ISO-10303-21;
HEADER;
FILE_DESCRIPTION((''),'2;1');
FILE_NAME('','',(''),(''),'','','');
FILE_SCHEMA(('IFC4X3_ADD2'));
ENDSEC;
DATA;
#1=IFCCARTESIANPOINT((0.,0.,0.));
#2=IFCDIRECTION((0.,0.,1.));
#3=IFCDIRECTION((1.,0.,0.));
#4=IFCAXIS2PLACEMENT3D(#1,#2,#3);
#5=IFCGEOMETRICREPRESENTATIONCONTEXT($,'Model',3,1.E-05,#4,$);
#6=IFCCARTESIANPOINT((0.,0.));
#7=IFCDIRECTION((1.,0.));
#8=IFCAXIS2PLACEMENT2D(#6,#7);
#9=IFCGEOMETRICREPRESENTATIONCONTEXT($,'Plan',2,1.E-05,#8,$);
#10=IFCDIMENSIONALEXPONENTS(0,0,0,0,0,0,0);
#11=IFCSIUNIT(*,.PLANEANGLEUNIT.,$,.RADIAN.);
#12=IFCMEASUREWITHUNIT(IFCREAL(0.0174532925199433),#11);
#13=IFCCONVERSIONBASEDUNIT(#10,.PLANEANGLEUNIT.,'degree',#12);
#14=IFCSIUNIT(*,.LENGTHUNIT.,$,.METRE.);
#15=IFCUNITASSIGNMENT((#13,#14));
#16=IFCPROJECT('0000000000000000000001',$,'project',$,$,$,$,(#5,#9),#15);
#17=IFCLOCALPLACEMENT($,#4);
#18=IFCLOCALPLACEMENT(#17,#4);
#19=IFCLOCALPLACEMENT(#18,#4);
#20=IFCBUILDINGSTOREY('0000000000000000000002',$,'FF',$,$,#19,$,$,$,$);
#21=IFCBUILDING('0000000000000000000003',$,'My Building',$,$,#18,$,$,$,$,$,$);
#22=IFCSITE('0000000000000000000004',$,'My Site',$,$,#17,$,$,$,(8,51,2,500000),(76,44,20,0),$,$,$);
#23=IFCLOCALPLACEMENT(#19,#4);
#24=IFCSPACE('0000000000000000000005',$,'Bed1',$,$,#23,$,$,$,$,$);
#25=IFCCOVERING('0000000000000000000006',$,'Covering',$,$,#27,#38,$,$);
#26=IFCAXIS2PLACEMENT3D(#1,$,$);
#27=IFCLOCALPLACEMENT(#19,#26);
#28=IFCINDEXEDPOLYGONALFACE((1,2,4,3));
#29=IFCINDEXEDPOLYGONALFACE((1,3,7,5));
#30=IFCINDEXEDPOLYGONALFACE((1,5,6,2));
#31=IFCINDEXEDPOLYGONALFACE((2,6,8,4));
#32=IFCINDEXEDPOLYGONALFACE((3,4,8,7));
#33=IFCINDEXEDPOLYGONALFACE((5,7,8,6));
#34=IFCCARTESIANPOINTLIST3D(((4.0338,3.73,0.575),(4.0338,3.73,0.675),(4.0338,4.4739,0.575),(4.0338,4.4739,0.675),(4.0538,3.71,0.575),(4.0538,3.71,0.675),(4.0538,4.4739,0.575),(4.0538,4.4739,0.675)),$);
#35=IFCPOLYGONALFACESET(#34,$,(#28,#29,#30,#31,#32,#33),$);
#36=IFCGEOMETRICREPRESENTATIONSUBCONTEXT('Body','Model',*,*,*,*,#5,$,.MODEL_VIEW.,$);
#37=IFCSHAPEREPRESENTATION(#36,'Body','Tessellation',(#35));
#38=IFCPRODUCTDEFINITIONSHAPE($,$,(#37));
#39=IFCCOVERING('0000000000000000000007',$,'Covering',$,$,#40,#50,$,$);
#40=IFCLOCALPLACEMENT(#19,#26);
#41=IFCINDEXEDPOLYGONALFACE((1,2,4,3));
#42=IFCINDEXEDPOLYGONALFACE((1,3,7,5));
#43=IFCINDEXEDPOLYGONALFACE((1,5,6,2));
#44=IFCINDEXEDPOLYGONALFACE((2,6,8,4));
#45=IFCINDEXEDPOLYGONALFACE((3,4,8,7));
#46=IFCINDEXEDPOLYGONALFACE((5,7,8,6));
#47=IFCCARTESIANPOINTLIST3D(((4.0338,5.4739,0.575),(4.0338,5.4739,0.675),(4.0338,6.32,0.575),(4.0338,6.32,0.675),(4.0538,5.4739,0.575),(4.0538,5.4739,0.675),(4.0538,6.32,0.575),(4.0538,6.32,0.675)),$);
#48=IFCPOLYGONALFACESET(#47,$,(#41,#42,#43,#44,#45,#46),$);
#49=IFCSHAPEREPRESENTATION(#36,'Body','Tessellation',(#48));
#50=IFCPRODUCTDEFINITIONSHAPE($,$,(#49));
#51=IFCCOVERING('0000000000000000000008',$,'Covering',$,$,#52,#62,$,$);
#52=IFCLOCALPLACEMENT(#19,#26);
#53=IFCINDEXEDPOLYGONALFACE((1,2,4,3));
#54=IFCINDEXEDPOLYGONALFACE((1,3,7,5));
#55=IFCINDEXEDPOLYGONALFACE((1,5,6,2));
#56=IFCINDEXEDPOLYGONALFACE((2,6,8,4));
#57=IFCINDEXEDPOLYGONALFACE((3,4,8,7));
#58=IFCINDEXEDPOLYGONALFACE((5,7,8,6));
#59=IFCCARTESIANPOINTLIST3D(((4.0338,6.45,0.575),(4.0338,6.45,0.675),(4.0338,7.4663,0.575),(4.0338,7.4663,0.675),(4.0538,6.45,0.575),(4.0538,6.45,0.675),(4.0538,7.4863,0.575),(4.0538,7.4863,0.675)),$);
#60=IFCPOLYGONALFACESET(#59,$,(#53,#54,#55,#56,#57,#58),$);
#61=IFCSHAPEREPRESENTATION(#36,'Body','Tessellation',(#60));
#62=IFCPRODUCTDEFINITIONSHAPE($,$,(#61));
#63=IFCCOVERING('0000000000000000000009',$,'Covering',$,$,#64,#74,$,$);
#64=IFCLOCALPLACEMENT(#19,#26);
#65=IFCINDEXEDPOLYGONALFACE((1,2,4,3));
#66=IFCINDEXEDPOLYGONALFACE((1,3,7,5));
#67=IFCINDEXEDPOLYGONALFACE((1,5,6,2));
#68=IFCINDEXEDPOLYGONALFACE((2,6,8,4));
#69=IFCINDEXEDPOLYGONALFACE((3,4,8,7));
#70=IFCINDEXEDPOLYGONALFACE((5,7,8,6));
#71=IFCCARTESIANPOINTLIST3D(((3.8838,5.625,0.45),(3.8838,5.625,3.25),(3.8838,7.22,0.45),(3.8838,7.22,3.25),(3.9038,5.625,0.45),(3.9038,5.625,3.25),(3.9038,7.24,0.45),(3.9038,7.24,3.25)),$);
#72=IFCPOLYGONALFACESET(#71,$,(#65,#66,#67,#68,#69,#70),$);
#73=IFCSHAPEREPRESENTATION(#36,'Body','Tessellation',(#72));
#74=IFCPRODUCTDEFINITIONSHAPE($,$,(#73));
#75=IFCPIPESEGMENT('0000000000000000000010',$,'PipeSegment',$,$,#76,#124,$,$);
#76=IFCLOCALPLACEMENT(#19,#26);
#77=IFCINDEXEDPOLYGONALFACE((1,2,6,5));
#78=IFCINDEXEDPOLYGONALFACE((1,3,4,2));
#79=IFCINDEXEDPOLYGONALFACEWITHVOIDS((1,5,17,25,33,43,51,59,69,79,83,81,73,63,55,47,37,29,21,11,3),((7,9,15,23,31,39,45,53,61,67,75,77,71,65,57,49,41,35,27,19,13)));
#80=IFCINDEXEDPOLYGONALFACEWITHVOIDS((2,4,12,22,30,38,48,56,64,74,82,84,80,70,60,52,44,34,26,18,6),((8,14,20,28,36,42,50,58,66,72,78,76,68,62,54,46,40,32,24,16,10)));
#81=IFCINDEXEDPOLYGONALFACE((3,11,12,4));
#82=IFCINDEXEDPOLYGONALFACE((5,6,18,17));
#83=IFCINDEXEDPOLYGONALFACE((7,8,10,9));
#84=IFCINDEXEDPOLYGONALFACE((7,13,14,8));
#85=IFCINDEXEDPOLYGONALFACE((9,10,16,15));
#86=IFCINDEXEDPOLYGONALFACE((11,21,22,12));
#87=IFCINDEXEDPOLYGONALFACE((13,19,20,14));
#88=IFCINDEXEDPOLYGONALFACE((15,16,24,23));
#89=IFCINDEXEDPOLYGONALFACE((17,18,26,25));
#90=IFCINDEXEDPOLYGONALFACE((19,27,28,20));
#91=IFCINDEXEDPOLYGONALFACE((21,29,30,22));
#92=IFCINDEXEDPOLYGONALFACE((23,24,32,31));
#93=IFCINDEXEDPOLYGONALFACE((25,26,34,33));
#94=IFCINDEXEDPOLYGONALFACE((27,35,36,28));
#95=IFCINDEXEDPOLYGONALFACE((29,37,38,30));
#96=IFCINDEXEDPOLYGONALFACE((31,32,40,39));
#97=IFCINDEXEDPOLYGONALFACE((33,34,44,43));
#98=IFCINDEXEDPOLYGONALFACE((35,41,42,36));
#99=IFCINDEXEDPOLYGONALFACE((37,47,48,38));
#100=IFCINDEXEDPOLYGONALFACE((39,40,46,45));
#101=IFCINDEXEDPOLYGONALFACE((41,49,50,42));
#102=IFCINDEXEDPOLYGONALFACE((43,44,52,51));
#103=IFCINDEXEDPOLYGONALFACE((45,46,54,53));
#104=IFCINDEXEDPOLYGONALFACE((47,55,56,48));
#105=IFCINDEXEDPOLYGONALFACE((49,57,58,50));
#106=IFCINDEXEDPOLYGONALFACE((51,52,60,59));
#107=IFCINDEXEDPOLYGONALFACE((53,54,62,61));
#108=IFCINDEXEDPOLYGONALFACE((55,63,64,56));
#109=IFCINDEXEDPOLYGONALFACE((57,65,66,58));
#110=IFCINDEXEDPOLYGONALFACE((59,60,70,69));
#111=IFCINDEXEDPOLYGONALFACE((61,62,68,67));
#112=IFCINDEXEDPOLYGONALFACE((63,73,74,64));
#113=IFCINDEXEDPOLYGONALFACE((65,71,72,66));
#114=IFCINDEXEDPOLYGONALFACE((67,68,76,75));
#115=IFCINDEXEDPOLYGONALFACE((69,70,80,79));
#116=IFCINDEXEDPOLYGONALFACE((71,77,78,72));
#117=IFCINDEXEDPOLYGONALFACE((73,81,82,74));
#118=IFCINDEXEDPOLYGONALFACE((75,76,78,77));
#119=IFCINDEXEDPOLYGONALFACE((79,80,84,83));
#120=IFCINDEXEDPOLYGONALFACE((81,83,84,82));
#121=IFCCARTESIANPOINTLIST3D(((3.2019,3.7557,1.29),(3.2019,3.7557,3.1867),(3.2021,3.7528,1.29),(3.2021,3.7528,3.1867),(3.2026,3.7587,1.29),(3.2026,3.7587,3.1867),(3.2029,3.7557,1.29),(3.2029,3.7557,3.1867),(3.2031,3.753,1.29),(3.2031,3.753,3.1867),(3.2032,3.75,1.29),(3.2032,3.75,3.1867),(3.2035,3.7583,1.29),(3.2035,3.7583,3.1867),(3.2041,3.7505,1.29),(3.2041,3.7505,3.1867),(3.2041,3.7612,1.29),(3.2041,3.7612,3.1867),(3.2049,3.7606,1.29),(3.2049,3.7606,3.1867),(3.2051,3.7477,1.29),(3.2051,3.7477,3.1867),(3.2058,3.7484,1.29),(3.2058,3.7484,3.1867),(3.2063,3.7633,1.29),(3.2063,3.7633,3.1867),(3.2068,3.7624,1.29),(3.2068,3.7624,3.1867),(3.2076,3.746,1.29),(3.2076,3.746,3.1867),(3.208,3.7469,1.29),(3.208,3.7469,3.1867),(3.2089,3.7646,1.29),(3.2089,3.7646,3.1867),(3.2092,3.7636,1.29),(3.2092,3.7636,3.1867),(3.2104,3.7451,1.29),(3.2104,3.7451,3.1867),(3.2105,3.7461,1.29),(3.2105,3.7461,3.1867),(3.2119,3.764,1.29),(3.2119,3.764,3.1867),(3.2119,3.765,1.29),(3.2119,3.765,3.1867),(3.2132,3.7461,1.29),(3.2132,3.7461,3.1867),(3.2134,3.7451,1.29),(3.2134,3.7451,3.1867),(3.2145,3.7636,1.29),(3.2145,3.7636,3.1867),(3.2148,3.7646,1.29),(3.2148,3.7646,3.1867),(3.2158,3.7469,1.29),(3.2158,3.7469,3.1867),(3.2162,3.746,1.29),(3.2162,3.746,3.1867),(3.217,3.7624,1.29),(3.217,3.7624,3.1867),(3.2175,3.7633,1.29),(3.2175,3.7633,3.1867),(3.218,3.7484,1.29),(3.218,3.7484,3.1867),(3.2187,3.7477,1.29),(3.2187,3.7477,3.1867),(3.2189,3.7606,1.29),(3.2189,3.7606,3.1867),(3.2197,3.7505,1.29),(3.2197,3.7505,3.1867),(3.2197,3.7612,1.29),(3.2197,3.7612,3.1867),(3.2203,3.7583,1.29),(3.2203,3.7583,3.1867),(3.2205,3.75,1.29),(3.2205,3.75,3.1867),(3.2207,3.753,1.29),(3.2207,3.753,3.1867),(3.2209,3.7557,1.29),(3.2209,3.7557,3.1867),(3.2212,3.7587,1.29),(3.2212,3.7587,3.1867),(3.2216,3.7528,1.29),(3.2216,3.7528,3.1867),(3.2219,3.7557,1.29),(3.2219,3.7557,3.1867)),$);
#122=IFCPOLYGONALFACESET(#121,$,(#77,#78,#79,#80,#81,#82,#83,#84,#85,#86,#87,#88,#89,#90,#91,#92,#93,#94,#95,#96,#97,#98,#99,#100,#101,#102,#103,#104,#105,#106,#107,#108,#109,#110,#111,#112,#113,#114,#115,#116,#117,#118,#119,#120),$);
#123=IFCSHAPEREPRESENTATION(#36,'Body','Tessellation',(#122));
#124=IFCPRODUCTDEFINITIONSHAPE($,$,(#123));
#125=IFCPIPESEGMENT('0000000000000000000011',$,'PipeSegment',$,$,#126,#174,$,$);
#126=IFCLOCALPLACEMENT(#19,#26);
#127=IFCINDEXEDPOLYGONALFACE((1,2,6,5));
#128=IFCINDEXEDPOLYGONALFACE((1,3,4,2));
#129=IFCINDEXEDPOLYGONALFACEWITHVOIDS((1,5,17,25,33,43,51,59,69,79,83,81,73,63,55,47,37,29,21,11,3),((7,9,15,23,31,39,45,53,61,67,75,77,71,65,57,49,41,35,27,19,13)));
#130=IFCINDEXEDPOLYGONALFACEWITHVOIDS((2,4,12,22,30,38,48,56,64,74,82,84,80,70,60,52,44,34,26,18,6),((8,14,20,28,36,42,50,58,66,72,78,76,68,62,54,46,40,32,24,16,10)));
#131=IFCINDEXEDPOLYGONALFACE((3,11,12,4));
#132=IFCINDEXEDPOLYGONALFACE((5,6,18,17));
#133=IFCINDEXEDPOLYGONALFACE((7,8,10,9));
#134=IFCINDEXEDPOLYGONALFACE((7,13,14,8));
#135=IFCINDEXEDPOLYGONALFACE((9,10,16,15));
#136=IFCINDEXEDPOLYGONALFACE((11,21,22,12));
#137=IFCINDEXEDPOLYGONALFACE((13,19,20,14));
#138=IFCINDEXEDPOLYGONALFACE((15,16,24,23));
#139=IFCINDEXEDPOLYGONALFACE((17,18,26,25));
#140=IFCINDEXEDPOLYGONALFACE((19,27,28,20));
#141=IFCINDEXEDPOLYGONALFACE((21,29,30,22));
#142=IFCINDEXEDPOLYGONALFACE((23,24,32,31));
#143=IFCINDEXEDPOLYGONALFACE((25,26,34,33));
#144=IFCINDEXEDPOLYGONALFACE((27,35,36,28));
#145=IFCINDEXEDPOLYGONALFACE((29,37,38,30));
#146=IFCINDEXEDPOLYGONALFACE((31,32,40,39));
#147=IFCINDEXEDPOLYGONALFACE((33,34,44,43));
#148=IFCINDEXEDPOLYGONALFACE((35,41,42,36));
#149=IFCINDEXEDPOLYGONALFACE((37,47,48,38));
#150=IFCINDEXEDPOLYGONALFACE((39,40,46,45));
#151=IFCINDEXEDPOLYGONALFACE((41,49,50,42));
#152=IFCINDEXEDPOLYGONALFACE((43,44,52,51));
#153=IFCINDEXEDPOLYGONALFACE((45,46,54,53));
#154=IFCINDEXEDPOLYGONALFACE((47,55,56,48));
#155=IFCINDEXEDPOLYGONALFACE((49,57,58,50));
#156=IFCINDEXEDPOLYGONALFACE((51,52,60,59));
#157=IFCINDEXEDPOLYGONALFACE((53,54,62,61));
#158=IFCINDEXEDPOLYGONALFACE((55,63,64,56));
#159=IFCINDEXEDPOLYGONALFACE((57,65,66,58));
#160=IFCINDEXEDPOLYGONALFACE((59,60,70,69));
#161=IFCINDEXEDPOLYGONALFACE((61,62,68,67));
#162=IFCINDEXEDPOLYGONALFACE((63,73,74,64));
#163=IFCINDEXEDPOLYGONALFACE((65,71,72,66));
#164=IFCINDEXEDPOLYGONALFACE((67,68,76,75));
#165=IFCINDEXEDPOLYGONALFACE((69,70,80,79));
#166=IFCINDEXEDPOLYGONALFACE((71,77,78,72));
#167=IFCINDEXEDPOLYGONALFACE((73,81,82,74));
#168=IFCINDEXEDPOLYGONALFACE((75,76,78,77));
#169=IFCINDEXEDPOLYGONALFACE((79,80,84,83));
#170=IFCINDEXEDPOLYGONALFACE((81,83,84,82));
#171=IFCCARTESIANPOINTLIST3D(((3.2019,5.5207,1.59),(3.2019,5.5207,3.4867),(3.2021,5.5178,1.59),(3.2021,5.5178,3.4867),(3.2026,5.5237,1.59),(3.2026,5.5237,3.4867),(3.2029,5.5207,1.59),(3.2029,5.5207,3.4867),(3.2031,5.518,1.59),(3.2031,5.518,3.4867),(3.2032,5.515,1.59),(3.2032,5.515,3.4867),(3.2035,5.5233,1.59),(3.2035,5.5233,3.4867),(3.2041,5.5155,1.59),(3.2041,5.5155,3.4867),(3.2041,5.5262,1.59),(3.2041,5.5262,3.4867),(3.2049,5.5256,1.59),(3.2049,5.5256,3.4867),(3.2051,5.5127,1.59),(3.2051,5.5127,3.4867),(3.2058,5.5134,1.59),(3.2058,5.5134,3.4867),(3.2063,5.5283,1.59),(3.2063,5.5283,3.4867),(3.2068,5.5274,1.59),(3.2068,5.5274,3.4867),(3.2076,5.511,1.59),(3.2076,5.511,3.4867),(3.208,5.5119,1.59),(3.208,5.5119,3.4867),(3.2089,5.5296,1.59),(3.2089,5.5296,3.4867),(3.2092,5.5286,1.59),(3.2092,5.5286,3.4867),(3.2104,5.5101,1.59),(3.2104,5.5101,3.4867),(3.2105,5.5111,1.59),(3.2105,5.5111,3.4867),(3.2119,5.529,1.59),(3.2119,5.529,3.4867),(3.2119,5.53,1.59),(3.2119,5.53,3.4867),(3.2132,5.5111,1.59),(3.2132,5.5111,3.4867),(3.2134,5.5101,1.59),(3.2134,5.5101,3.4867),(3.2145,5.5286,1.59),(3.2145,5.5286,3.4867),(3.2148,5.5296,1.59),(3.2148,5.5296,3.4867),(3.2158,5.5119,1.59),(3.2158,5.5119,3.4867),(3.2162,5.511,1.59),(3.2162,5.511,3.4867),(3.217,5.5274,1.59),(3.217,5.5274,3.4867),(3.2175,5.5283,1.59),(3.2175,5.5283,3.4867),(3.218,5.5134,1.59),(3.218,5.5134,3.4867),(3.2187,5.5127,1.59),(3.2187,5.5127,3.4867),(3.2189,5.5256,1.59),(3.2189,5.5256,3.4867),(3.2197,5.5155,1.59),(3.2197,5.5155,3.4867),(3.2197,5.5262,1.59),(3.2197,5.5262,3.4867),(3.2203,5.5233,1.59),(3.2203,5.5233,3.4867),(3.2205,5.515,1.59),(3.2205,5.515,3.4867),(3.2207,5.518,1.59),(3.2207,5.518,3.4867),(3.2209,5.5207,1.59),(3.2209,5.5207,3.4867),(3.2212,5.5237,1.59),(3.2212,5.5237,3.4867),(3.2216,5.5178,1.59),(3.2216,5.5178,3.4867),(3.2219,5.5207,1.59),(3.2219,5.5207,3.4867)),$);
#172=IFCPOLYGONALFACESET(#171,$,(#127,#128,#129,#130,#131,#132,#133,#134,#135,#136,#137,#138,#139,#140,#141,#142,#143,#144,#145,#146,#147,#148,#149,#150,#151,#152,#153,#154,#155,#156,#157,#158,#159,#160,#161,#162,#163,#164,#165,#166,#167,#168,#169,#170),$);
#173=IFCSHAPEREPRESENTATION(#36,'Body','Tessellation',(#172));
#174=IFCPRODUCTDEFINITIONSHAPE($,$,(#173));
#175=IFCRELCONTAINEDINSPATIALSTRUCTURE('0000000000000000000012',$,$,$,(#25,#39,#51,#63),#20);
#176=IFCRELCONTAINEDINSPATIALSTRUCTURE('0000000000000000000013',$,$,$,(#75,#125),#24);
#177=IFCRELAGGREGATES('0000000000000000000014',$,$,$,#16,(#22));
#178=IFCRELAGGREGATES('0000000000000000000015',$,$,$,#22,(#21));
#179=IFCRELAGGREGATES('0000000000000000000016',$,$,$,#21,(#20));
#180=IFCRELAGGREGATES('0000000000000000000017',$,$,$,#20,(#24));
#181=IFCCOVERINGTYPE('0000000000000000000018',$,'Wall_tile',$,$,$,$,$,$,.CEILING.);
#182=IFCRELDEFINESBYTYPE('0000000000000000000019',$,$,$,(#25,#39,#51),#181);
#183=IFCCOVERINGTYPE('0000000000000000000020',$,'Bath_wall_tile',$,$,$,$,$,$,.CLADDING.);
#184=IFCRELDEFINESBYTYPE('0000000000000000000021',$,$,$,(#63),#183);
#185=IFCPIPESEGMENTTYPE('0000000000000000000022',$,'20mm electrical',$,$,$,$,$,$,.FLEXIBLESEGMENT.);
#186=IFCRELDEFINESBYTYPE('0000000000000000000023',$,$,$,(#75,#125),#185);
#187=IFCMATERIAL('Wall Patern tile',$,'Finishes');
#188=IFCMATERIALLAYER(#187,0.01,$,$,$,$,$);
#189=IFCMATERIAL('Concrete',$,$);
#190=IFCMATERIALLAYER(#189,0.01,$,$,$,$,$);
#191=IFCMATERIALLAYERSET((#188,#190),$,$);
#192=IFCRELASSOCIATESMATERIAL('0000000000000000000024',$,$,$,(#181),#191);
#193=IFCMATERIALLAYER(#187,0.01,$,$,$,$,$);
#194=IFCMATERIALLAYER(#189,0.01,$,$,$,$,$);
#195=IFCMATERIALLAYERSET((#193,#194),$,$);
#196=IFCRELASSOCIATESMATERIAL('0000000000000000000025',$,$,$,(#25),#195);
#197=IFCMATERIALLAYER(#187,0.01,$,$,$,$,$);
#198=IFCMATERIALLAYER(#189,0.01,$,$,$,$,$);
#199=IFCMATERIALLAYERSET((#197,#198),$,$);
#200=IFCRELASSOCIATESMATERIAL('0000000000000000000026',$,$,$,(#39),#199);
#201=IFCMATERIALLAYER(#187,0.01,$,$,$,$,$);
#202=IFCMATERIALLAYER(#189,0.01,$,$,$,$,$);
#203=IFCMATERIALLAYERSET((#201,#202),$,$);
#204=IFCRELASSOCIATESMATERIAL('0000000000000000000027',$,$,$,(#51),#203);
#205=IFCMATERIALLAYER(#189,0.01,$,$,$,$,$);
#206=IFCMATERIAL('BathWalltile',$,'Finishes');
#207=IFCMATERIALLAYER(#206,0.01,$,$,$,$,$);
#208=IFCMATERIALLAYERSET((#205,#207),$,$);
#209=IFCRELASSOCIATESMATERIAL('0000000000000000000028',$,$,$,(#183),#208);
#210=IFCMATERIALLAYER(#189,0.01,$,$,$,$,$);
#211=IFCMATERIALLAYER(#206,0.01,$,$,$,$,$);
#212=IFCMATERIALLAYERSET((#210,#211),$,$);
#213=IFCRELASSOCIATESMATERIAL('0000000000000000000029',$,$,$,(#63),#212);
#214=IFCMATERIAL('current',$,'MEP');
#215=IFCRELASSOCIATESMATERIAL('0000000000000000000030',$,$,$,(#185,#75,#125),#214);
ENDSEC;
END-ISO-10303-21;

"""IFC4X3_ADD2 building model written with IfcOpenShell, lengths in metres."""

from ifc_helpers import new_model, entity, si_unit, converted_unit, frame, origin_with_axes, origin_2d_with_axis, place, context, subcontext, project, spatial, line, indexed_curve, hollow_circle, outline, extrude, material, layer, layer_set, layer_usage, material_profile, profile_set, profile_usage, type_object, element, save


model = new_model("IFC4X3_ADD2")

# Units and contexts
model_context = context("Model", 3, precision=1e-05, world=origin_with_axes())
plan_context = context("Plan", 2, precision=1e-05, world=origin_2d_with_axis())
body_context_1 = subcontext(model_context, "Body", "Model", "MODEL_VIEW")
ifc_project = project(units=[converted_unit("PLANEANGLEUNIT", "degree", entity("IfcReal", 0.0174532925199433), si_unit("PLANEANGLEUNIT", "RADIAN"), dimensions=[0, 0, 0, 0, 0, 0, 0]), si_unit("LENGTHUNIT", "METRE")], contexts=[model_context, plan_context])

# Site, building, storey
site_placement = place(None, origin_with_axes())
site = spatial("IfcSite", under=ifc_project, at=site_placement, Name="My Site", RefLatitude=(8, 51, 2, 500000), RefLongitude=(76, 44, 20, 0))
building_placement = place(site_placement, origin_with_axes())
building = spatial("IfcBuilding", under=site, at=building_placement, Name="My Building")
storey_placement = place(building_placement, origin_with_axes())
storey = spatial("IfcBuildingStorey", under=building, at=storey_placement, Name="FF")

# Coverings
ifc_material_1 = material(Name="Wall Patern tile", Category="Finishes")
ifc_material_2 = material(Name="Concrete")
ifc_layer_1 = layer(ifc_material_1, 0.01)
ifc_layer_2 = layer(ifc_material_2, 0.01)
ifc_layer_set_1 = layer_set([ifc_layer_1, ifc_layer_2])
covering_type_1 = type_object("IfcCoveringType", Name="Wall_tile", PredefinedType="CEILING", material=ifc_layer_set_1)
ifc_layer_3 = layer(ifc_material_1, 0.01)
ifc_layer_4 = layer(ifc_material_2, 0.01)
ifc_layer_set_2 = layer_set([ifc_layer_3, ifc_layer_4])
ifc_layer_usage_1 = layer_usage(ifc_layer_set_2, "AXIS2", "NEGATIVE", 0.0)
covering_1_placement = place(storey_placement, frame((4.0538, 4.4739, 0.575), z_axis=(0.0, 0.0, 1.0), x_axis=(0.0, -1.0, 0.0)))
element("IfcCovering", 1, at=covering_1_placement, inside=storey, type_object=covering_type_1, material=ifc_layer_usage_1, Name="Covering", context=body_context_1, shape_type="SweptSolid", body=[
    extrude(outline(indexed_curve([(0.0, -0.02), (0.0, 0.0), (0.7639, 0.0), (0.7439, -0.02)], segments=[line(1, 2, 3, 4, 1)])), origin_with_axes(), (0.0, 0.0, 1.0), 0.1),
])
ifc_layer_5 = layer(ifc_material_1, 0.01)
ifc_layer_6 = layer(ifc_material_2, 0.01)
ifc_layer_set_3 = layer_set([ifc_layer_5, ifc_layer_6])
ifc_layer_usage_2 = layer_usage(ifc_layer_set_3, "AXIS2", "NEGATIVE", 0.0)
covering_2_placement = place(storey_placement, frame((4.0538, 6.32, 0.575), z_axis=(0.0, 0.0, 1.0), x_axis=(0.0, -1.0, 0.0)))
element("IfcCovering", 2, at=covering_2_placement, inside=storey, type_object=covering_type_1, material=ifc_layer_usage_2, Name="Covering", context=body_context_1, shape_type="SweptSolid", body=[
    extrude(outline(indexed_curve([(0.0, -0.02), (0.0, 0.0), (0.8461, 0.0), (0.8461, -0.02)], segments=[line(1, 2, 3, 4, 1)])), origin_with_axes(), (0.0, 0.0, 1.0), 0.1),
])
ifc_layer_7 = layer(ifc_material_1, 0.01)
ifc_layer_8 = layer(ifc_material_2, 0.01)
ifc_layer_set_4 = layer_set([ifc_layer_7, ifc_layer_8])
ifc_layer_usage_3 = layer_usage(ifc_layer_set_4, "AXIS2", "NEGATIVE", 0.0)
covering_3_placement = place(storey_placement, frame((4.0538, 7.4863, 0.575), z_axis=(0.0, 0.0, 1.0), x_axis=(0.0, -1.0, 0.0)))
element("IfcCovering", 3, at=covering_3_placement, inside=storey, type_object=covering_type_1, material=ifc_layer_usage_3, Name="Covering", context=body_context_1, shape_type="SweptSolid", body=[
    extrude(outline(indexed_curve([(0.02, -0.02), (0.0, 0.0), (1.0363, 0.0), (1.0363, -0.02)], segments=[line(1, 2, 3, 4, 1)])), origin_with_axes(), (0.0, 0.0, 1.0), 0.1),
])
ifc_layer_9 = layer(ifc_material_2, 0.01)
ifc_material_3 = material(Name="BathWalltile", Category="Finishes")
ifc_layer_10 = layer(ifc_material_3, 0.01)
ifc_layer_set_5 = layer_set([ifc_layer_9, ifc_layer_10])
ifc_layer_usage_4 = layer_usage(ifc_layer_set_5, "AXIS2", "NEGATIVE", 0.0)
ifc_layer_11 = layer(ifc_material_2, 0.01)
ifc_layer_12 = layer(ifc_material_3, 0.01)
ifc_layer_set_6 = layer_set([ifc_layer_11, ifc_layer_12])
covering_type_2 = type_object("IfcCoveringType", Name="Bath_wall_tile", PredefinedType="CLADDING", material=ifc_layer_set_6)
covering_4_placement = place(storey_placement, frame((3.9038, 7.24, 0.45), z_axis=(0.0, 0.0, 1.0), x_axis=(0.0, -1.0, 0.0)))
element("IfcCovering", 4, at=covering_4_placement, inside=storey, type_object=covering_type_2, material=ifc_layer_usage_4, Name="Covering", context=body_context_1, shape_type="SweptSolid", body=[
    extrude(outline(indexed_curve([(0.02, -0.02), (0.0, 0.0), (1.615, 0.0), (1.615, -0.02)], segments=[line(1, 2, 3, 4, 1)])), origin_with_axes(), (0.0, 0.0, 1.0), 2.8),
])

# Shared definitions
space_1_placement = place(storey_placement, origin_with_axes())
space_1 = spatial("IfcSpace", under=storey, at=space_1_placement, Name="Bed1")

# Pipe segments
ifc_material_4 = material(Name="current", Category="MEP")
ifc_material_profile_1 = material_profile(ifc_material_4, hollow_circle(Radius=0.01, WallThickness=0.001))
ifc_profile_set_1 = profile_set([ifc_material_profile_1], Name="current")
ifc_profile_usage_1 = profile_usage(ifc_profile_set_1, cardinal=5)
pipe_segment_type = type_object("IfcPipeSegmentType", Name="20mm electrical", PredefinedType="FLEXIBLESEGMENT", material=ifc_profile_set_1)
pipe_segment_1_placement = place(space_1_placement, frame((3.2119, 3.755, 1.29), z_axis=(0.0, 0.0, 1.0), x_axis=(0.0, 1.0, 0.0)))
element("IfcPipeSegment", 5, at=pipe_segment_1_placement, inside=space_1, type_object=pipe_segment_type, material=ifc_profile_usage_1, Name="PipeSegment", context=body_context_1, shape_type="SweptSolid", body=[
    extrude(hollow_circle(Radius=0.01, WallThickness=0.001), origin_with_axes(), (0.0, 0.0, 1.0), 1.8967),
])
ifc_profile_usage_2 = profile_usage(ifc_profile_set_1, cardinal=5)
pipe_segment_2_placement = place(space_1_placement, frame((3.2119, 5.52, 1.59), z_axis=(0.0, 0.0, 1.0), x_axis=(0.0, 1.0, 0.0)))
element("IfcPipeSegment", 6, at=pipe_segment_2_placement, inside=space_1, type_object=pipe_segment_type, material=ifc_profile_usage_2, Name="PipeSegment", context=body_context_1, shape_type="SweptSolid", body=[
    extrude(hollow_circle(Radius=0.01, WallThickness=0.001), origin_with_axes(), (0.0, 0.0, 1.0), 1.8967),
])

save(model, "model.ifc")
